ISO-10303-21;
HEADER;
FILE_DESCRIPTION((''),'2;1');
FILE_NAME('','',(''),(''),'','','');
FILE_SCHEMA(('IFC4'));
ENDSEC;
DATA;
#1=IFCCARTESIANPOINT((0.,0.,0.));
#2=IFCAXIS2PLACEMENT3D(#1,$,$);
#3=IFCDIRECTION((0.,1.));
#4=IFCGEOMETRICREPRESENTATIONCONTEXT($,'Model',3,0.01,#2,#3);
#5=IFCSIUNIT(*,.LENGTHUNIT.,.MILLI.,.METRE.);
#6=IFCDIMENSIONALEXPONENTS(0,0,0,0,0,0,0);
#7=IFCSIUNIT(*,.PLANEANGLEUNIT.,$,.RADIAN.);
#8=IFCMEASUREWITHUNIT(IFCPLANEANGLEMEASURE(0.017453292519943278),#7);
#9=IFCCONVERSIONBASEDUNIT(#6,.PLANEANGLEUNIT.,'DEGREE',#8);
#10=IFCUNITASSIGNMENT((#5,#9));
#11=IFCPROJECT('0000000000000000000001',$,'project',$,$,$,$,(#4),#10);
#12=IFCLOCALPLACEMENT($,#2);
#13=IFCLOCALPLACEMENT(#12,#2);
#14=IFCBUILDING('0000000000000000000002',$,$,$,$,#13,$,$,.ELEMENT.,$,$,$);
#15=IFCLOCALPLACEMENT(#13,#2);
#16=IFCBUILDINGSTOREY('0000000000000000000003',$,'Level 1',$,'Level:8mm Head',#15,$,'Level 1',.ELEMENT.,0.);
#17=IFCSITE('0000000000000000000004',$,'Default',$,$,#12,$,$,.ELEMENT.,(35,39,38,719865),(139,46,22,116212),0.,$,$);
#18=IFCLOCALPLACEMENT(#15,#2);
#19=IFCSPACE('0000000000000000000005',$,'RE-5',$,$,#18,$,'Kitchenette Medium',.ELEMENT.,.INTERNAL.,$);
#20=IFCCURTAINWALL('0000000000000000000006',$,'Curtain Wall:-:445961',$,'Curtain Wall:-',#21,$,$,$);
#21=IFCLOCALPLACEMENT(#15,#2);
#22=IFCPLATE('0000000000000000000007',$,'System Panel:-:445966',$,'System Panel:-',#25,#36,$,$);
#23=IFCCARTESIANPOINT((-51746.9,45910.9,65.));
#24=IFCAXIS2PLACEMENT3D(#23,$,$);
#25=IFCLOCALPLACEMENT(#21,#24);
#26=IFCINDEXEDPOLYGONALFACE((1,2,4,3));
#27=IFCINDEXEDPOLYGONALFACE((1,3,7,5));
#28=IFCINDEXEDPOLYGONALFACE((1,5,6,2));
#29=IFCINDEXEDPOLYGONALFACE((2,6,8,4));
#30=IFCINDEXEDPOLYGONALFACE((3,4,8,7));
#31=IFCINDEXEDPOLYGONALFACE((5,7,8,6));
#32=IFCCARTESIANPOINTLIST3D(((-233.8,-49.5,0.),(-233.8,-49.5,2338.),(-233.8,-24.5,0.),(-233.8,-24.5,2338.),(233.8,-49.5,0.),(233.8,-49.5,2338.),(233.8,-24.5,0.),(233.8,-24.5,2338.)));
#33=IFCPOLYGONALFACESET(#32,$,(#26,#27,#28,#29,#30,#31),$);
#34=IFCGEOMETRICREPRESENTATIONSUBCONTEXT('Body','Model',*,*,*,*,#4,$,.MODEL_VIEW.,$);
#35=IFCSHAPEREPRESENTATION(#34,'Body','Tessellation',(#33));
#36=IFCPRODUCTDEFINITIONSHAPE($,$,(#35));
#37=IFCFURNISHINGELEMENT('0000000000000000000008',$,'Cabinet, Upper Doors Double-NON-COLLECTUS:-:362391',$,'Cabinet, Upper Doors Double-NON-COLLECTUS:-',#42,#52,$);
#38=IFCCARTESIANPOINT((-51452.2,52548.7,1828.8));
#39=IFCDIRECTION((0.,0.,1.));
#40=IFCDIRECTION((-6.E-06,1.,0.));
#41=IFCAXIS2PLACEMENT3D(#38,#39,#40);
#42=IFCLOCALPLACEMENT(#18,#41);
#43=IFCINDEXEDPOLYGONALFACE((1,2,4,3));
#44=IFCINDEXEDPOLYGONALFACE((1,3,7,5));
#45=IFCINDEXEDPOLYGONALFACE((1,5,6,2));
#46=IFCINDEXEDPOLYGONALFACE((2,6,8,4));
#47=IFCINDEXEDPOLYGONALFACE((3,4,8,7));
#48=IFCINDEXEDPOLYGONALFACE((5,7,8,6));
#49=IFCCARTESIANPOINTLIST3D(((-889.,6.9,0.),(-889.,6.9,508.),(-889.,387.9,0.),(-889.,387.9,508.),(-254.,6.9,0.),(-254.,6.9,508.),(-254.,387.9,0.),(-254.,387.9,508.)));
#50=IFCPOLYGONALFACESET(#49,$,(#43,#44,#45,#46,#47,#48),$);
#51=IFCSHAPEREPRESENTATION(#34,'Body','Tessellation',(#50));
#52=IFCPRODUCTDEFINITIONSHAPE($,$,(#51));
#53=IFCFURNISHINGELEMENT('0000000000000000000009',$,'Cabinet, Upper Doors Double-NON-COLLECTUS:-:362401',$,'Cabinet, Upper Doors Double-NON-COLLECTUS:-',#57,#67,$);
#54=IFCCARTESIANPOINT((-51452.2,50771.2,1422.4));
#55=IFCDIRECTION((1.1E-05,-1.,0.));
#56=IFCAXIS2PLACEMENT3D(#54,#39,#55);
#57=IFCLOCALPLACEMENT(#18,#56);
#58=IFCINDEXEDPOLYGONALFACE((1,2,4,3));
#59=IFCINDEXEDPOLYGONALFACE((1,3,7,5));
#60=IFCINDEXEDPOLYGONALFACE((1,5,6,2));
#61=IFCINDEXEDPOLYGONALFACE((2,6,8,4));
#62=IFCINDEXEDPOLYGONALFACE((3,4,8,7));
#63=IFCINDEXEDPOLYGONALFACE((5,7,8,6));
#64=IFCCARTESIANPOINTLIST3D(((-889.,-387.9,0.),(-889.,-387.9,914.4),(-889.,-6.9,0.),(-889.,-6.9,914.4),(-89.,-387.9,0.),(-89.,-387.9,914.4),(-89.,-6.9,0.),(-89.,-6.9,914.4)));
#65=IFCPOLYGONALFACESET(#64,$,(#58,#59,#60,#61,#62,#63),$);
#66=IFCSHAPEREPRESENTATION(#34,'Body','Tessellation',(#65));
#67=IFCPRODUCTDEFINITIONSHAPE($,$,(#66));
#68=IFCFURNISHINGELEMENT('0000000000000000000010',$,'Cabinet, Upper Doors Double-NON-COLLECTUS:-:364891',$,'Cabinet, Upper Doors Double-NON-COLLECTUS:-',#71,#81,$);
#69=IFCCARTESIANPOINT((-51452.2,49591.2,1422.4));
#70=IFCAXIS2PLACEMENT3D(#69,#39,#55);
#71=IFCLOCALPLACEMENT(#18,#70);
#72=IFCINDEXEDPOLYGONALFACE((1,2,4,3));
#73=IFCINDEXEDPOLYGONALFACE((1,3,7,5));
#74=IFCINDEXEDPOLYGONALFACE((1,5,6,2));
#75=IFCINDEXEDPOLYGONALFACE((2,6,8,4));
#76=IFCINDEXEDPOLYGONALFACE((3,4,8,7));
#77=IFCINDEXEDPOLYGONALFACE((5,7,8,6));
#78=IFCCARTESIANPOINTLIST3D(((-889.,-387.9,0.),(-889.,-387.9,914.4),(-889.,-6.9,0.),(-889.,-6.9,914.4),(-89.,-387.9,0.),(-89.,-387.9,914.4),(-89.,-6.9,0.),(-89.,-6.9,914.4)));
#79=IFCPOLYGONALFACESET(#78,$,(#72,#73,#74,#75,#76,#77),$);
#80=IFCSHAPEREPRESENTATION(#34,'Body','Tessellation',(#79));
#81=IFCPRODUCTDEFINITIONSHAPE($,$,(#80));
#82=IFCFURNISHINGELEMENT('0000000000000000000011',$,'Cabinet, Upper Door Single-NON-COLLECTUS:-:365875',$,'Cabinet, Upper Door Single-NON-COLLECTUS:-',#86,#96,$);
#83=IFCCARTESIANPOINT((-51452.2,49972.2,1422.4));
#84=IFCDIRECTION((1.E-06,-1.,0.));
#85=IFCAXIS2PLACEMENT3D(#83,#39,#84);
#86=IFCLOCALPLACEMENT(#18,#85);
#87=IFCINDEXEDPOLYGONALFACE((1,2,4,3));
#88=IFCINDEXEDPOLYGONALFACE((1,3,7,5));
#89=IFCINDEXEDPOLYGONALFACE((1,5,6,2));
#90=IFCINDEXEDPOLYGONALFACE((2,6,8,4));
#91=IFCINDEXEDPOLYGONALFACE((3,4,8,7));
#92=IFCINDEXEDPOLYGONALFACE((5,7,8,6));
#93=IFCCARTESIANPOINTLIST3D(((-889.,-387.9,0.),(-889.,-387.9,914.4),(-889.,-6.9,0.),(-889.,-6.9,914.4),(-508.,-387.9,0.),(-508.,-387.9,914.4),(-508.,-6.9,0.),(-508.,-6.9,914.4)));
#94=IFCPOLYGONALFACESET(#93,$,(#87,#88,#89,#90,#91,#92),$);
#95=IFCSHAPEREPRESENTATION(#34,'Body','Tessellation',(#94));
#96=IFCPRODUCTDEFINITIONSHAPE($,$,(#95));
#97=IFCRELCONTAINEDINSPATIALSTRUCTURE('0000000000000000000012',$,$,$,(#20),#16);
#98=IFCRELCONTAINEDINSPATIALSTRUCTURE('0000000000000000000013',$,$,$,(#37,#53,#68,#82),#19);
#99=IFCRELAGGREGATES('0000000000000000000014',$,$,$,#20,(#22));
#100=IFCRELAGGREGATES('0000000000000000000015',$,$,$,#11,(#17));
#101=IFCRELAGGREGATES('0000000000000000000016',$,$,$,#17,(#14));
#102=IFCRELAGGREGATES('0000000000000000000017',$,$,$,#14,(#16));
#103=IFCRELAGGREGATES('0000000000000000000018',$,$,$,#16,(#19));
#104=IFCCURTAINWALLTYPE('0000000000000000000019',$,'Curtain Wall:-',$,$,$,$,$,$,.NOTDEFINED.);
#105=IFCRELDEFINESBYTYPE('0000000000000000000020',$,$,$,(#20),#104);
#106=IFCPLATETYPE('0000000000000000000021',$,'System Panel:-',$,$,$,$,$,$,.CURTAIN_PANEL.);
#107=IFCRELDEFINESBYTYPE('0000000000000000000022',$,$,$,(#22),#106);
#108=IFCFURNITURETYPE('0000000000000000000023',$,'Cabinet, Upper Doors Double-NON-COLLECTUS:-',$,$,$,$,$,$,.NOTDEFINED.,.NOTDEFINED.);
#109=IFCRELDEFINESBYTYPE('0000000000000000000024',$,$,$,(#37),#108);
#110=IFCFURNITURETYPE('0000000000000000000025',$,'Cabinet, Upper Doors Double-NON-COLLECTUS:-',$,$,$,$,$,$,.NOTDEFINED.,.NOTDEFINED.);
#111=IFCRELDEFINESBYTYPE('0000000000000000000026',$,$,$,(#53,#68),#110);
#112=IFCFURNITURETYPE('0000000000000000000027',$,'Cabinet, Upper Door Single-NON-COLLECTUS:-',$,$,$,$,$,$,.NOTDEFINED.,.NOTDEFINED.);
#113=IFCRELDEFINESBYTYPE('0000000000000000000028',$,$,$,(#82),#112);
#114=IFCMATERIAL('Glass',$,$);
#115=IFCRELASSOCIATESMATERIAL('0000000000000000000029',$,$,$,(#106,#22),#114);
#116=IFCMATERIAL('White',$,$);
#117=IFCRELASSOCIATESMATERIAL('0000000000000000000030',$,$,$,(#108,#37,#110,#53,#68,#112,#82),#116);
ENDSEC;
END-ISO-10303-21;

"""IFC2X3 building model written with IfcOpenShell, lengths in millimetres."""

from ifc_helpers import new_model, entity, si_unit, converted_unit, direction, frame, frame_2d, origin, origin_2d_with_axis, place, context, subcontext, project, spatial, rectangle, extrude, source, transform, mapped, material, type_object, type_shapes, element, aggregate, save


model = new_model("IFC2X3")

# Units and contexts
model_context = context("Model", 3, precision=0.01, world=origin(), true_north=direction((0.0, 1.0)))
body_context = subcontext(model_context, "Body", "Model", "MODEL_VIEW")
ifc_project = project(units=[si_unit("LENGTHUNIT", "METRE", prefix="MILLI"), converted_unit("PLANEANGLEUNIT", "DEGREE", entity("IfcPlaneAngleMeasure", 0.017453292519943278), si_unit("PLANEANGLEUNIT", "RADIAN"), dimensions=[0, 0, 0, 0, 0, 0, 0])], contexts=[model_context])

# Site, building, storey
site_placement = place(None, origin())
site = spatial("IfcSite", under=ifc_project, at=site_placement, Name="Default", CompositionType="ELEMENT", RefLatitude=(35, 39, 38, 719865), RefLongitude=(139, 46, 22, 116212), RefElevation=0.0)
building_placement = place(site_placement, origin())
building = spatial("IfcBuilding", under=site, at=building_placement, CompositionType="ELEMENT")
storey_placement = place(building_placement, origin())
storey = spatial("IfcBuildingStorey", under=building, at=storey_placement, Name="Level 1", ObjectType="Level:8mm Head", LongName="Level 1", CompositionType="ELEMENT", Elevation=0.0)

# Curtain wall
curtain_wall_type = type_object("IfcCurtainWallType", Name="Curtain Wall:-", PredefinedType="NOTDEFINED")
curtain_wall_placement = place(storey_placement, origin())
curtain_wall = element("IfcCurtainWall", 1, at=curtain_wall_placement, inside=storey, type_object=curtain_wall_type, Name="Curtain Wall:-:445961", ObjectType="Curtain Wall:-")

# Plate
ifc_material_1 = material(Name="Glass")
plate_type = type_object("IfcPlateType", Name="System Panel:-", PredefinedType="CURTAIN_PANEL", material=ifc_material_1)
shared_shape_1 = source(origin(), body_context, "Body", "SweptSolid", [
    extrude(rectangle(XDim=25.0, YDim=467.6, at=frame_2d((0.0, 0.0), x_axis=(1.0, 0.0))), frame((0.0, -37.0, 0.0), z_axis=(0.0, 0.0, 1.0), x_axis=(0.0, 1.0, 0.0)), (0.0, 0.0, 1.0), 2338.0),
])
type_shapes(plate_type, [shared_shape_1])
plate_placement = place(curtain_wall_placement, frame((-51746.9, 45910.9, 65.0)))
plate = element("IfcPlate", 2, at=plate_placement, type_object=plate_type, material=ifc_material_1, Name="System Panel:-:445966", ObjectType="System Panel:-", context=body_context, shape_type="MappedRepresentation", body=[
    mapped(shared_shape_1, transform((0.0, 0.0, 0.0), scale=1.0)),
])

aggregate(curtain_wall, [plate])

# Shared definitions
ifc_material_2 = material(Name="White")

# Shared definitions
space_1_placement = place(storey_placement, origin())
space_1 = spatial("IfcSpace", under=storey, at=space_1_placement, Name="RE-5", LongName="Kitchenette Medium", CompositionType="ELEMENT", InteriorOrExteriorSpace="INTERNAL")

# Furnishing elements
furniture_type_1 = type_object("IfcFurnitureType", Name="Cabinet, Upper Doors Double-NON-COLLECTUS:-", AssemblyPlace="NOTDEFINED", material=ifc_material_2)
shared_shape_2 = source(origin(), body_context, "Body", "SweptSolid", [
    extrude(rectangle(XDim=381.0, YDim=635.0, at=origin_2d_with_axis()), frame((-571.5, 197.4, 0.0), z_axis=(0.0, 0.0, 1.0), x_axis=(0.0, 1.0, 0.0)), (0.0, 0.0, 1.0), 508.0),
])
type_shapes(furniture_type_1, [shared_shape_2])
furnishing_1_placement = place(space_1_placement, frame((-51452.2, 52548.7, 1828.8), z_axis=(0.0, 0.0, 1.0), x_axis=(-0.000006, 1.0, 0.0)))
element("IfcFurnishingElement", 3, at=furnishing_1_placement, inside=space_1, type_object=furniture_type_1, material=ifc_material_2, Name="Cabinet, Upper Doors Double-NON-COLLECTUS:-:362391", ObjectType="Cabinet, Upper Doors Double-NON-COLLECTUS:-", context=body_context, shape_type="MappedRepresentation", body=[
    mapped(shared_shape_2, transform((0.0, 0.0, 0.0), scale=1.0)),
])
furniture_type_2 = type_object("IfcFurnitureType", Name="Cabinet, Upper Doors Double-NON-COLLECTUS:-", AssemblyPlace="NOTDEFINED", material=ifc_material_2)
shared_shape_3 = source(origin(), body_context, "Body", "SweptSolid", [
    extrude(rectangle(XDim=800.0, YDim=381.0, at=frame_2d((0.0, 0.0), x_axis=(1.0, 0.0))), frame((-489.0, -197.4, 0.0), z_axis=(0.0, 0.0, 1.0), x_axis=(-1.0, 0.0, 0.0)), (0.0, 0.0, 1.0), 914.4),
])
type_shapes(furniture_type_2, [shared_shape_3])
for number, where, z_axis, x_axis, name in (
    (4, (-51452.2, 50771.2, 1422.4), (0.0, 0.0, 1.0), (0.000011, -1.0, 0.0), "Cabinet, Upper Doors Double-NON-COLLECTUS:-:362401"),
    (5, (-51452.2, 49591.2, 1422.4), (0.0, 0.0, 1.0), (0.000011, -1.0, 0.0), "Cabinet, Upper Doors Double-NON-COLLECTUS:-:364891"),
):
    element("IfcFurnishingElement", number, at=place(space_1_placement, frame(where, z_axis=z_axis, x_axis=x_axis)), inside=space_1, type_object=furniture_type_2, material=ifc_material_2, Name=name, ObjectType="Cabinet, Upper Doors Double-NON-COLLECTUS:-", context=body_context, shape_type="MappedRepresentation", body=[
        mapped(shared_shape_3, transform((0.0, 0.0, 0.0), scale=1.0)),
    ])
furniture_type_3 = type_object("IfcFurnitureType", Name="Cabinet, Upper Door Single-NON-COLLECTUS:-", AssemblyPlace="NOTDEFINED", material=ifc_material_2)
shared_shape_4 = source(origin(), body_context, "Body", "SweptSolid", [
    extrude(rectangle(XDim=381.0, YDim=381.0, at=frame_2d((0.0, 0.0), x_axis=(1.0, 0.0))), frame((-698.5, -197.4, 0.0), z_axis=(0.0, 0.0, 1.0), x_axis=(-1.0, 0.0, 0.0)), (0.0, 0.0, 1.0), 914.4),
])
type_shapes(furniture_type_3, [shared_shape_4])
furnishing_2_placement = place(space_1_placement, frame((-51452.2, 49972.2, 1422.4), z_axis=(0.0, 0.0, 1.0), x_axis=(0.000001, -1.0, 0.0)))
element("IfcFurnishingElement", 6, at=furnishing_2_placement, inside=space_1, type_object=furniture_type_3, material=ifc_material_2, Name="Cabinet, Upper Door Single-NON-COLLECTUS:-:365875", ObjectType="Cabinet, Upper Door Single-NON-COLLECTUS:-", context=body_context, shape_type="MappedRepresentation", body=[
    mapped(shared_shape_4, transform((0.0, 0.0, 0.0), scale=1.0)),
])

save(model, "model.ifc")
